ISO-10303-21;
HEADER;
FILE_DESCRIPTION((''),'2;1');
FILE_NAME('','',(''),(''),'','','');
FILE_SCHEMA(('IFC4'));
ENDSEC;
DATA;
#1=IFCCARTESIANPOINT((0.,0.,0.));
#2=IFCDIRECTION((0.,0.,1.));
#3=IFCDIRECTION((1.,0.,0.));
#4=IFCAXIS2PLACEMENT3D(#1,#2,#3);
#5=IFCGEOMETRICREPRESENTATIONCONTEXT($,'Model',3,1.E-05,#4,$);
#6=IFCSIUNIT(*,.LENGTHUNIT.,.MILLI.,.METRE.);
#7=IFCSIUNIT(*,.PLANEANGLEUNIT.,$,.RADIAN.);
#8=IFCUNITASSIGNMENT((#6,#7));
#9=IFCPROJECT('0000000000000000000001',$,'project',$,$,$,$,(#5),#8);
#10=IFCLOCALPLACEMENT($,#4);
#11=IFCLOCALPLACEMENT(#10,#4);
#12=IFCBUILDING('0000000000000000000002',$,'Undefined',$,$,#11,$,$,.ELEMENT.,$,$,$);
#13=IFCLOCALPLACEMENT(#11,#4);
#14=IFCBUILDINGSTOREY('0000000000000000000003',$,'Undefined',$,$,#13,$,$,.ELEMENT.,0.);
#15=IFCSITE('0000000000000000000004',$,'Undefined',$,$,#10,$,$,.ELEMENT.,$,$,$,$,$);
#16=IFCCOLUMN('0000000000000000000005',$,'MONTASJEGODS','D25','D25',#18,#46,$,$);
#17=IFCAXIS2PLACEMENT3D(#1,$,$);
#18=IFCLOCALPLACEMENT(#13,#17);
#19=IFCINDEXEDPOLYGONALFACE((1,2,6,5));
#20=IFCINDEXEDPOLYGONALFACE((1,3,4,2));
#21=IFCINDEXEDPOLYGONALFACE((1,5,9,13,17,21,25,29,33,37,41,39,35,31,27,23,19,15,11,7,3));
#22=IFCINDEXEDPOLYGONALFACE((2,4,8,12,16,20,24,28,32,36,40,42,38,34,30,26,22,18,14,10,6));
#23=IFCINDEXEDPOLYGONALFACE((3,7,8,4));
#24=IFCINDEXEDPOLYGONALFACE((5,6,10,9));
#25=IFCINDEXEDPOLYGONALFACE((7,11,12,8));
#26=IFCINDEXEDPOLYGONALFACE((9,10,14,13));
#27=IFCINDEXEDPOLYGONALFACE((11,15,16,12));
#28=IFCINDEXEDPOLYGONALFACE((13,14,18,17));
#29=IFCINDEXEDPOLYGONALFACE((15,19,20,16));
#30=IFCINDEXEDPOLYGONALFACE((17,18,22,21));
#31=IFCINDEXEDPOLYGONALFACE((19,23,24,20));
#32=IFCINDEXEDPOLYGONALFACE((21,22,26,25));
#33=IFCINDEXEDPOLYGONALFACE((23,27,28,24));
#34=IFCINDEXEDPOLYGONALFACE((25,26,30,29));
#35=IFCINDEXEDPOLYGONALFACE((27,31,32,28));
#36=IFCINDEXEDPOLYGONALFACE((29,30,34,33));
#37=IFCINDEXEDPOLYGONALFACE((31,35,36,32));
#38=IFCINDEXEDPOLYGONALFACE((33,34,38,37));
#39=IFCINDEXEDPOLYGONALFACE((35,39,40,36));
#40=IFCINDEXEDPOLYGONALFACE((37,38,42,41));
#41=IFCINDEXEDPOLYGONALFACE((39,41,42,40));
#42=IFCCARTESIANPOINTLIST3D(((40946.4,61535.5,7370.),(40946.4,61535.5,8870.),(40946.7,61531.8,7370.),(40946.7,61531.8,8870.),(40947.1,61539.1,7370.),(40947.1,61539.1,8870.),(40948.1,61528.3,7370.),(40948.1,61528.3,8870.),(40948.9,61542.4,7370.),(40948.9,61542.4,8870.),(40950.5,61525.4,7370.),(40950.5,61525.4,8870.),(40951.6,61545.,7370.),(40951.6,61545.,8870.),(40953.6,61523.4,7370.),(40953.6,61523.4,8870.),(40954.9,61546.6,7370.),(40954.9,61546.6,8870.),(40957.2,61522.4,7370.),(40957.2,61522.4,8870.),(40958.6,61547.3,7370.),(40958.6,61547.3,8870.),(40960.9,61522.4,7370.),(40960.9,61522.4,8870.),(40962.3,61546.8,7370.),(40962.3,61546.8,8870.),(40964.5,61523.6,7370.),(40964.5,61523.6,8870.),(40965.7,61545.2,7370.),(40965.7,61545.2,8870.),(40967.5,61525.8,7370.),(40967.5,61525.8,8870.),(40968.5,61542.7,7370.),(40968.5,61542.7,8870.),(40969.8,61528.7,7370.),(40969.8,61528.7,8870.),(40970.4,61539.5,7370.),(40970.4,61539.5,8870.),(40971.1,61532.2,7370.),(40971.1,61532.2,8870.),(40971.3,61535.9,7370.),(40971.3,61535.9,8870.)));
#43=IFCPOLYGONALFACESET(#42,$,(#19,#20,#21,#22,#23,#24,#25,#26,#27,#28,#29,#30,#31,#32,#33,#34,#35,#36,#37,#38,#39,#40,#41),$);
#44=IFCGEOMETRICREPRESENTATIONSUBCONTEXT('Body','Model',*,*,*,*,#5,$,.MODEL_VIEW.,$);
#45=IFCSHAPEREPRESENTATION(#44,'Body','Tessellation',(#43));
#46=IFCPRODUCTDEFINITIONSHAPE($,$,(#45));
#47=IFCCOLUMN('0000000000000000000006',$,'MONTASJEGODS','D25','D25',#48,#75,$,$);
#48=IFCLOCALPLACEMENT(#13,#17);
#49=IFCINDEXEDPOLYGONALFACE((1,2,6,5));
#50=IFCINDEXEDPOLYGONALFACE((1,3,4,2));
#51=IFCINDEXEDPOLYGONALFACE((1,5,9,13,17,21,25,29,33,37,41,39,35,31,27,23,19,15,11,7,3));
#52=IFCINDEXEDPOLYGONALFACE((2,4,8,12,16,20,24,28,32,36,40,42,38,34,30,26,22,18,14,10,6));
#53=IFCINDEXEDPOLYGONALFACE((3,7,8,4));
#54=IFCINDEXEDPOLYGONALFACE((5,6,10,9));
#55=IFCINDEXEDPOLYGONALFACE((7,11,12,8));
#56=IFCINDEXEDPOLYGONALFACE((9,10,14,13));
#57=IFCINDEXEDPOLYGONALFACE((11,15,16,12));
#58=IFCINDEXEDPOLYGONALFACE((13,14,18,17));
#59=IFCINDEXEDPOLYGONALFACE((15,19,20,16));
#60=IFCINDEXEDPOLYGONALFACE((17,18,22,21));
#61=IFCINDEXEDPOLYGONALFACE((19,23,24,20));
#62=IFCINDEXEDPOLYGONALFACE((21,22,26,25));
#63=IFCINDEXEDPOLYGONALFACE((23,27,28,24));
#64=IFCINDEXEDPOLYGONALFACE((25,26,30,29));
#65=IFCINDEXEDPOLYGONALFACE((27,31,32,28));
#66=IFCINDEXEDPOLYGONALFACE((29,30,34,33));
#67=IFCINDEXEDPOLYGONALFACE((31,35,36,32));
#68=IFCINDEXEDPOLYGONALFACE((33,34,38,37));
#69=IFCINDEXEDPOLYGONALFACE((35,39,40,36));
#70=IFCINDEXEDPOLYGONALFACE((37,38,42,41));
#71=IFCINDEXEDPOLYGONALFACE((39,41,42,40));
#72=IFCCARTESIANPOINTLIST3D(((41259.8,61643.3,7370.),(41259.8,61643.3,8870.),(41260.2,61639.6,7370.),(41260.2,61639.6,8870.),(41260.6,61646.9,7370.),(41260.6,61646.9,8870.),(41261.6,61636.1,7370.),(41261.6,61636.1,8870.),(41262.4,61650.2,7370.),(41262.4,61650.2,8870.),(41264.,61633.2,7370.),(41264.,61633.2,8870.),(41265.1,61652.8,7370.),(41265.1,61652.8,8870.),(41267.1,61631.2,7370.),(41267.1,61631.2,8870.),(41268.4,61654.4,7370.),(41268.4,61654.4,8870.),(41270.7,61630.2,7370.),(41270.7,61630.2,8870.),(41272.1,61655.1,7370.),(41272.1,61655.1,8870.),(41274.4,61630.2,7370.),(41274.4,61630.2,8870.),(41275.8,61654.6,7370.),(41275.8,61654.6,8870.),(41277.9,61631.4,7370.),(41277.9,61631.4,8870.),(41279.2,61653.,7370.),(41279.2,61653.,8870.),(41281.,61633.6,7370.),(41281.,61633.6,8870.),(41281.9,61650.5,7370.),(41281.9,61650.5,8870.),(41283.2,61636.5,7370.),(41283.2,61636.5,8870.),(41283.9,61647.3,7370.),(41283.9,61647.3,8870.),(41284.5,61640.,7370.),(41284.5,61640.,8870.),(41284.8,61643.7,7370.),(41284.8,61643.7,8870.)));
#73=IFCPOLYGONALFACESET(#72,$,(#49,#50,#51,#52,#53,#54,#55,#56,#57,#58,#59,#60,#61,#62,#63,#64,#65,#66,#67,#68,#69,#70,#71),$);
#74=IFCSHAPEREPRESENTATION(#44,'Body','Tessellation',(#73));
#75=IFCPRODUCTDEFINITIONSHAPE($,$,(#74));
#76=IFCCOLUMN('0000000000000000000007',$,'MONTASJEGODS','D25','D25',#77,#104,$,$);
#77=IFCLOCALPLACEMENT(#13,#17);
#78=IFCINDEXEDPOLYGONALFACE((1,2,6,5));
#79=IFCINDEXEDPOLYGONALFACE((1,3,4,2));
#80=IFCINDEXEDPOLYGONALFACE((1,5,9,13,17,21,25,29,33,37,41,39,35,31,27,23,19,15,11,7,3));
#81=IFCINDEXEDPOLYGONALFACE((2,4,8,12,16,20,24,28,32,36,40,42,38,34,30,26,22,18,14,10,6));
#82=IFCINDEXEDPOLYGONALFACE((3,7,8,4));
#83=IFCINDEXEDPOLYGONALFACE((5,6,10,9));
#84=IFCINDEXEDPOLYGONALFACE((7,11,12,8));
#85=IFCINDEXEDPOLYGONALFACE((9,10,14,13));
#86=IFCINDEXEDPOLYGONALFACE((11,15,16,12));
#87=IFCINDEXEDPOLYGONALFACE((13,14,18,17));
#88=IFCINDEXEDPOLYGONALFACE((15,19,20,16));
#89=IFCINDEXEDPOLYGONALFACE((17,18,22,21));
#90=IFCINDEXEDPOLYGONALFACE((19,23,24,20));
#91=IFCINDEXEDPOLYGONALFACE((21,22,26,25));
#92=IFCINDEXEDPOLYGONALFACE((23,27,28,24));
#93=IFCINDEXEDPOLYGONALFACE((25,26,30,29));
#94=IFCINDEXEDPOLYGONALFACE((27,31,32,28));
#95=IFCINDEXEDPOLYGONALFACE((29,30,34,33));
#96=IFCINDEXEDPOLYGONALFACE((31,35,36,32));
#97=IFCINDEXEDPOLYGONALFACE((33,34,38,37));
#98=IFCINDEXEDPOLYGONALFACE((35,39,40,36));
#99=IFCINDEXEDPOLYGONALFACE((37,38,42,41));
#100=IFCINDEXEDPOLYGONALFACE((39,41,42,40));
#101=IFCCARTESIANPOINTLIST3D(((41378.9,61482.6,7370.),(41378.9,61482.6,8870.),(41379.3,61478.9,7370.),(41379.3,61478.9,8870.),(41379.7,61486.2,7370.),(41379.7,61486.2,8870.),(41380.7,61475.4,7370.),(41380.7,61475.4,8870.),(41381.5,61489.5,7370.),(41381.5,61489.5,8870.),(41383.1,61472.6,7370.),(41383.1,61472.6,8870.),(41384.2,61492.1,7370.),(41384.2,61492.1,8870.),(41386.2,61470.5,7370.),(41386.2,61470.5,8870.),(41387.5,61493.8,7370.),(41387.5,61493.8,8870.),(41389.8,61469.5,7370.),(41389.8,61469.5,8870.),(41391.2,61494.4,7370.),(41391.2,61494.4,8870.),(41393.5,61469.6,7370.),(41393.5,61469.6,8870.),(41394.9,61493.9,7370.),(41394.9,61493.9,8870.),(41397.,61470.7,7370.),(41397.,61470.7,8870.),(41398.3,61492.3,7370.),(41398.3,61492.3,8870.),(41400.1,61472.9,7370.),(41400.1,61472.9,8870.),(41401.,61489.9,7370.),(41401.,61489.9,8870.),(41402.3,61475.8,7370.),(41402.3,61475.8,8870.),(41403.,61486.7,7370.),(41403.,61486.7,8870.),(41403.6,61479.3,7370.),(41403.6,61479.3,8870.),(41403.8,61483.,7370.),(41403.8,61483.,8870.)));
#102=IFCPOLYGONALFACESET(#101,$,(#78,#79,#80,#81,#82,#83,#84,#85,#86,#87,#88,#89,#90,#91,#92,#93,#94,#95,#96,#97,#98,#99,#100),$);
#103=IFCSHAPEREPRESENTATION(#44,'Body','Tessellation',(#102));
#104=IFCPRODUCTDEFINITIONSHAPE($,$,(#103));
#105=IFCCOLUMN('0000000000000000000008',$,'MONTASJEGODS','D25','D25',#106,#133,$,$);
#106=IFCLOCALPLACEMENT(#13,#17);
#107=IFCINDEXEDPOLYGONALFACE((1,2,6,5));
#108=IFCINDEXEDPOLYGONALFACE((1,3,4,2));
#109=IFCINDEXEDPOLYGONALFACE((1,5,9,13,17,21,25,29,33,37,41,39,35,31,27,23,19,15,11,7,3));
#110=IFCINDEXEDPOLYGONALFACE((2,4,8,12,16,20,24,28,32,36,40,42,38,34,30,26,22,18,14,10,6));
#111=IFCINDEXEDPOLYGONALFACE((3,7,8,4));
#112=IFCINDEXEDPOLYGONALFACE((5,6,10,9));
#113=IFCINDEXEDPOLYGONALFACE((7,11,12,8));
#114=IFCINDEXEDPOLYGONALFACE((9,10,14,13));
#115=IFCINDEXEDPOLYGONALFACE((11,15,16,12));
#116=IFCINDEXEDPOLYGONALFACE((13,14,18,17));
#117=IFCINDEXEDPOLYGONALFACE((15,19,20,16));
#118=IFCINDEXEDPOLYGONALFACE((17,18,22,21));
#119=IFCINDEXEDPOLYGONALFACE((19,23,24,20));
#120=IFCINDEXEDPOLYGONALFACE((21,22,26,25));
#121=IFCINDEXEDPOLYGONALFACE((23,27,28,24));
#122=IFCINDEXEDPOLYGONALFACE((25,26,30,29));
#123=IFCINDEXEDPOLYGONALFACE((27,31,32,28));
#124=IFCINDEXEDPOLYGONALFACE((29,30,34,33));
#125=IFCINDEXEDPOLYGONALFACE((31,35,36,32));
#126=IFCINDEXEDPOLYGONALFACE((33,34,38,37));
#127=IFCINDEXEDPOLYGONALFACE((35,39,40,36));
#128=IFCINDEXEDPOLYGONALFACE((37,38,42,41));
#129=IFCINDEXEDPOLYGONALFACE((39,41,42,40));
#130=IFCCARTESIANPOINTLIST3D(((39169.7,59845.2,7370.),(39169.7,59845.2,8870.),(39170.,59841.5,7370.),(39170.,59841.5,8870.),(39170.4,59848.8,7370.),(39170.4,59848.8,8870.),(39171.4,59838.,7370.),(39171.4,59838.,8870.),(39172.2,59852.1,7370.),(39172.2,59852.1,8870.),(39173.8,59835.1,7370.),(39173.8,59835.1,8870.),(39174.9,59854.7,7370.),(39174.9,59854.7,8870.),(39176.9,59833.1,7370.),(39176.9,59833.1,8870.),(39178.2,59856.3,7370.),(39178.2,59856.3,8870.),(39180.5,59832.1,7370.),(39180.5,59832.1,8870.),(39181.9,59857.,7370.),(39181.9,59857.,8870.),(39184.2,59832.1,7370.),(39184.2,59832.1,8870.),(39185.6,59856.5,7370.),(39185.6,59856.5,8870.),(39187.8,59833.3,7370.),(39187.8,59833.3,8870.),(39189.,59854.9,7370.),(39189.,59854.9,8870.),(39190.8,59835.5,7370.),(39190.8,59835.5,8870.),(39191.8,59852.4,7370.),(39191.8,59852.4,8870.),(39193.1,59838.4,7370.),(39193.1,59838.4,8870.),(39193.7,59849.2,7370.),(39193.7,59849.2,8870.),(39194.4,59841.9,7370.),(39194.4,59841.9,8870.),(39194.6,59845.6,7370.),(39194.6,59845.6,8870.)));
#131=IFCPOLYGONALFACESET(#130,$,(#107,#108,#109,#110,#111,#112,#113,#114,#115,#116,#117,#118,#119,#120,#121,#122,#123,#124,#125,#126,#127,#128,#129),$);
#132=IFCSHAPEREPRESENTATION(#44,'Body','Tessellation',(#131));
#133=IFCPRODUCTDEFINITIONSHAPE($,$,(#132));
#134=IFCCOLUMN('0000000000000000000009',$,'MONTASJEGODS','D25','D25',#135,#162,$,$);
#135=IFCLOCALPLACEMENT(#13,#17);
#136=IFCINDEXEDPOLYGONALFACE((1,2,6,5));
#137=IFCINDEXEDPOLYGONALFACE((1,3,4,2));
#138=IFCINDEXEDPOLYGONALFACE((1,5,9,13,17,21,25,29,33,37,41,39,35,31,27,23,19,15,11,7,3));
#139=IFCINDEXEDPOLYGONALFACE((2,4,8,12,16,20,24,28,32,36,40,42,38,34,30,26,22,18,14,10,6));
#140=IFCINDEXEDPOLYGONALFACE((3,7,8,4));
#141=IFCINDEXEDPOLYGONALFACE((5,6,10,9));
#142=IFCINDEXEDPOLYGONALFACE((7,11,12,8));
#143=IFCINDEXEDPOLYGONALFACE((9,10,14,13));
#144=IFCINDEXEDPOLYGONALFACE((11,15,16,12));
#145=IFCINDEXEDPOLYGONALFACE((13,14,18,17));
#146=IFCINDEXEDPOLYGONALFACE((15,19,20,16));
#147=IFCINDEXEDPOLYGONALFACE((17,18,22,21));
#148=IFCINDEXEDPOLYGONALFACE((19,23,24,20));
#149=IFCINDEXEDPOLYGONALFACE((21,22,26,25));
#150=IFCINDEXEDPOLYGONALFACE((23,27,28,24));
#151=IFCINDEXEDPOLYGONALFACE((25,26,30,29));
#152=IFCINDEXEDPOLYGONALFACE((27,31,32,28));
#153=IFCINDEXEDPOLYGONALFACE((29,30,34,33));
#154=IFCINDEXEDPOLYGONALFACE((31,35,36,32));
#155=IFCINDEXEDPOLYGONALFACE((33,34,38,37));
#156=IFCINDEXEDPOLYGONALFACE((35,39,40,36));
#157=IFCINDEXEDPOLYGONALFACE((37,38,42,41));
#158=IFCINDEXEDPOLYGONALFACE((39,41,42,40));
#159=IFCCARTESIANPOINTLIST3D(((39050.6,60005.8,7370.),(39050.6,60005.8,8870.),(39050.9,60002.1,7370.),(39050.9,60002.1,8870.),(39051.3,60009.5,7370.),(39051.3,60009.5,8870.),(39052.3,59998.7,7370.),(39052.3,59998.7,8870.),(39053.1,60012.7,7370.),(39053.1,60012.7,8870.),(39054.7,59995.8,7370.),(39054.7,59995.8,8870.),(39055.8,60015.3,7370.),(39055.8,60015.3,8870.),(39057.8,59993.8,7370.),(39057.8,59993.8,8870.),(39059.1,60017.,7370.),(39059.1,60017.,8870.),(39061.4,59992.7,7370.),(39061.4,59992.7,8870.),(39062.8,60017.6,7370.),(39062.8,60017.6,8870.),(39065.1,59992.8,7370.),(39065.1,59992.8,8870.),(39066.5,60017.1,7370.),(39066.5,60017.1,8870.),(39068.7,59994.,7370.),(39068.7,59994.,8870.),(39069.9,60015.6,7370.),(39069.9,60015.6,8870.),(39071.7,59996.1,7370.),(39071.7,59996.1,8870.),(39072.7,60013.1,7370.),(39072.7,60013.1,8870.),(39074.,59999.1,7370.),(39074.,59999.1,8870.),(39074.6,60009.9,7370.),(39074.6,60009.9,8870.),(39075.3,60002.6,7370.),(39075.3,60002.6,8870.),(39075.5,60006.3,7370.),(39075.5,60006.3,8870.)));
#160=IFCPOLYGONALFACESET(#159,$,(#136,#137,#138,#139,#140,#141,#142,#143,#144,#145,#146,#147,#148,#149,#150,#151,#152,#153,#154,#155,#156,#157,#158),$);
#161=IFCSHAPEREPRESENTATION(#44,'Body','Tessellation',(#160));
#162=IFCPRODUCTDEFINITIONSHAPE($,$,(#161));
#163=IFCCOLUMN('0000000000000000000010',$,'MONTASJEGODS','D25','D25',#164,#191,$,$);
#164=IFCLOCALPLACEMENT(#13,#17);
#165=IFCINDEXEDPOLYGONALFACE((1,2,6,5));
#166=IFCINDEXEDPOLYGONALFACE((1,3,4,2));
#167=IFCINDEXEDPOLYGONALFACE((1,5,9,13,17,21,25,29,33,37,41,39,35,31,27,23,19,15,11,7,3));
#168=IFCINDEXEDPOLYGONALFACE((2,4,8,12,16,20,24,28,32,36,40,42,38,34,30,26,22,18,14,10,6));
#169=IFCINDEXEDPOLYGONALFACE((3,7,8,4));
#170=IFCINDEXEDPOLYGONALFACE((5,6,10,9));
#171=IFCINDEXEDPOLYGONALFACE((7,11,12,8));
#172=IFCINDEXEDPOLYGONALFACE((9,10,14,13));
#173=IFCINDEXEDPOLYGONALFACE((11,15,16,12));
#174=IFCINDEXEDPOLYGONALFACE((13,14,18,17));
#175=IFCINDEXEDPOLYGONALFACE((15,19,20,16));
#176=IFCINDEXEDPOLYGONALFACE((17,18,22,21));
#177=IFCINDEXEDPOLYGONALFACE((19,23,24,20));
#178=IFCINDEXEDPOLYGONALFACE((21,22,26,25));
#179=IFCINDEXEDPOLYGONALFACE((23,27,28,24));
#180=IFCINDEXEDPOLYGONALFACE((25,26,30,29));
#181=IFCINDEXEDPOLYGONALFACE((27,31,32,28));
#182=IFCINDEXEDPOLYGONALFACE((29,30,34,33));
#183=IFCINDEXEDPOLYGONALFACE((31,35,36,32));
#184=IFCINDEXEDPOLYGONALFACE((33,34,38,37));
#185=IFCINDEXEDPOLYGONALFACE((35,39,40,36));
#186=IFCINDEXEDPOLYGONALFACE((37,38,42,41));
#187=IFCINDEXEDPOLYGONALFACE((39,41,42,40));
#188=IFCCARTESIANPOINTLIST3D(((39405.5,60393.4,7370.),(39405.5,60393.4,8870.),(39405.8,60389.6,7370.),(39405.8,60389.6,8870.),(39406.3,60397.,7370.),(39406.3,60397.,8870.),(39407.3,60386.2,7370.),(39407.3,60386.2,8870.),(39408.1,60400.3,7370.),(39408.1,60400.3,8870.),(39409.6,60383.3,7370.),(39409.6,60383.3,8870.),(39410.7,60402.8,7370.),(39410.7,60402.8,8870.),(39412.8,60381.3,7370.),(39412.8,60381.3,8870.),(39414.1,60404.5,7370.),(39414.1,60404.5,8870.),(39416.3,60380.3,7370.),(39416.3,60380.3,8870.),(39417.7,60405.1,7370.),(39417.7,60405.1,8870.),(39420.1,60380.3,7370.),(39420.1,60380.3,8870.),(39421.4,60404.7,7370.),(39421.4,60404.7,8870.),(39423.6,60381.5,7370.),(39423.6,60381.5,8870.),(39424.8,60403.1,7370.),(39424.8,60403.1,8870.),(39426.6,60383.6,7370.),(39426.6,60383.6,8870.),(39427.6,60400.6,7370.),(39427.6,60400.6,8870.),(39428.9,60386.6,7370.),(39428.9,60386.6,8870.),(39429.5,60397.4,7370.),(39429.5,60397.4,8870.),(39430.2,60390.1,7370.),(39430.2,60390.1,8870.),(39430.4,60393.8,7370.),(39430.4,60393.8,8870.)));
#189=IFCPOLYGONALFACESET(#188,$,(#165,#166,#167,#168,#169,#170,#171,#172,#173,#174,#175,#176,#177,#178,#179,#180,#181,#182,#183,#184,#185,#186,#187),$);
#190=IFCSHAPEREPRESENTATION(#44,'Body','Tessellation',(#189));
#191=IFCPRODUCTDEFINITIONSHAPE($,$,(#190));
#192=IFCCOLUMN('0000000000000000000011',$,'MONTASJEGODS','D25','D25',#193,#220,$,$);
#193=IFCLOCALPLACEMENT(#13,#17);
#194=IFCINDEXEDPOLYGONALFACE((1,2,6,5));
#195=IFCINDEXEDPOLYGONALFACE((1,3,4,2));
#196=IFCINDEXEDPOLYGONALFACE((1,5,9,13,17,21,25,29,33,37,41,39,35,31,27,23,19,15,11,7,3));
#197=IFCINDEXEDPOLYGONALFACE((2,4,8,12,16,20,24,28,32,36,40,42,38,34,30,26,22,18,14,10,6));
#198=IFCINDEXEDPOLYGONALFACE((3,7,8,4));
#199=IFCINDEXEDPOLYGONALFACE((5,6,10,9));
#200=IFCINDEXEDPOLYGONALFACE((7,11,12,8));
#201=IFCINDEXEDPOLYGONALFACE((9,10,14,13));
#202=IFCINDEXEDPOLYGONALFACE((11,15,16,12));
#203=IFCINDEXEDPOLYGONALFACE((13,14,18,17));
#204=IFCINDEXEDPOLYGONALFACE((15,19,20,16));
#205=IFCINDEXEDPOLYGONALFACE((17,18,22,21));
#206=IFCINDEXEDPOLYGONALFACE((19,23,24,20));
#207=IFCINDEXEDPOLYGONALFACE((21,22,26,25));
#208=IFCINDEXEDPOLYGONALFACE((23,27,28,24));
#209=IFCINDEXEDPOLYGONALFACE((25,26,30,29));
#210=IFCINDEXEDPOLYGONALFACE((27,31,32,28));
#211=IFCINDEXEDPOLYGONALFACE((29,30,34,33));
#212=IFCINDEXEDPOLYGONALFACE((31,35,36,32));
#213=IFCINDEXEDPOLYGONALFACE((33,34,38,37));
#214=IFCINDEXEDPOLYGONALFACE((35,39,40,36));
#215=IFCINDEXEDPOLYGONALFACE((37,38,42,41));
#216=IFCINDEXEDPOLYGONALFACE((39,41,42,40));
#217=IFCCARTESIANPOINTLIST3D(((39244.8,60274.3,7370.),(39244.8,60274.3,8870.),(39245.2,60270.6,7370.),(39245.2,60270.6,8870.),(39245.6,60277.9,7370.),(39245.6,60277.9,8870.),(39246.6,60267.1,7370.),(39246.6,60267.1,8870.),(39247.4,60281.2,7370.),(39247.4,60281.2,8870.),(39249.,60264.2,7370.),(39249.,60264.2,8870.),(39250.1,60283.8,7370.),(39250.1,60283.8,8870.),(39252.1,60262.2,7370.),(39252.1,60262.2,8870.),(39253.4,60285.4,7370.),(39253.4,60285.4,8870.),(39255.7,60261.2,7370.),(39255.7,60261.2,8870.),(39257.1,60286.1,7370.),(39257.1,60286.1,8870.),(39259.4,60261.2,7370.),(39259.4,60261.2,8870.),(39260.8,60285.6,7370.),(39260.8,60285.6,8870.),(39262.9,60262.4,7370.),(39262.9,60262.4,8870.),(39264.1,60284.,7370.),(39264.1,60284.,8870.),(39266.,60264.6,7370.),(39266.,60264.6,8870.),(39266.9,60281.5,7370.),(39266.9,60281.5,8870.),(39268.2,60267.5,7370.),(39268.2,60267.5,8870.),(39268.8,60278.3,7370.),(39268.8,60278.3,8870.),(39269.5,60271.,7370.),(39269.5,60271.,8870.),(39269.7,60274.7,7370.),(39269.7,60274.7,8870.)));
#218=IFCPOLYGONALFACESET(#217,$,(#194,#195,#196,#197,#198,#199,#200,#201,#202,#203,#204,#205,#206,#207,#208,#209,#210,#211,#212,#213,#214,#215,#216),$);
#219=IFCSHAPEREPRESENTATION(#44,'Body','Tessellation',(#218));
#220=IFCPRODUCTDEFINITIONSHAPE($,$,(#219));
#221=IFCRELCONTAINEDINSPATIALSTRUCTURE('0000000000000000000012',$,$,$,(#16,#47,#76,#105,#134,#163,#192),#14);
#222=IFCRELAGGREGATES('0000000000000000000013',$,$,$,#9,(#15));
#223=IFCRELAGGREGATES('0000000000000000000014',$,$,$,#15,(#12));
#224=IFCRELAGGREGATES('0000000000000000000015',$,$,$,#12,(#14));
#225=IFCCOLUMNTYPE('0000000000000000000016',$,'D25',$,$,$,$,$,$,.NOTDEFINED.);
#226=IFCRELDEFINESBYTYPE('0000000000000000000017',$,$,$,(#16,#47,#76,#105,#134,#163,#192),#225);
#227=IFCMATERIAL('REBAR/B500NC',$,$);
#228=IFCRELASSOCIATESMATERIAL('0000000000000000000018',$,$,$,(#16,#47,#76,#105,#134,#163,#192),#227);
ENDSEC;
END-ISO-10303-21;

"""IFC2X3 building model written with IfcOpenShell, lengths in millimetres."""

from ifc_helpers import new_model, si_unit, frame, origin_with_axes, origin_2d_with_axis, place, context, subcontext, project, spatial, circle, extrude, material, type_object, element, save


model = new_model("IFC2X3")

# Units and contexts
model_context = context("Model", 3, precision=1e-05, world=origin_with_axes())
body_context = subcontext(model_context, "Body", "Model", "MODEL_VIEW")
ifc_project = project(units=[si_unit("LENGTHUNIT", "METRE", prefix="MILLI"), si_unit("PLANEANGLEUNIT", "RADIAN")], contexts=[model_context])

# Site, building, storey
site_placement = place(None, origin_with_axes())
site = spatial("IfcSite", under=ifc_project, at=site_placement, Name="Undefined", CompositionType="ELEMENT")
building_placement = place(site_placement, origin_with_axes())
building = spatial("IfcBuilding", under=site, at=building_placement, Name="Undefined", CompositionType="ELEMENT")
storey_placement = place(building_placement, origin_with_axes())
storey = spatial("IfcBuildingStorey", under=building, at=storey_placement, Name="Undefined", CompositionType="ELEMENT", Elevation=0.0)

# Columns
ifc_material_1 = material(Name="REBAR/B500NC")
column_type_1 = type_object("IfcColumnType", Name="D25", PredefinedType="NOTDEFINED")
for number, where, z_axis, x_axis, name in (
    (1, (40958.8, 61534.8, 7370.0), (0.0, 0.0, 1.0), (-0.892819, -0.450415, 0.0), "MONTASJEGODS"),
    (2, (41272.3, 61642.6, 7370.0), (0.0, 0.0, 1.0), (-0.892819, -0.450415, 0.0), "MONTASJEGODS"),
    (3, (41391.4, 61481.9, 7370.0), (0.0, 0.0, 1.0), (-0.892819, -0.450415, 0.0), "MONTASJEGODS"),
    (4, (39182.1, 59844.5, 7370.0), (0.0, 0.0, 1.0), (-0.892819, -0.450415, 0.0), "MONTASJEGODS"),
    (5, (39063.0, 60005.1, 7370.0), (0.0, 0.0, 1.0), (-0.892819, -0.450415, 0.0), "MONTASJEGODS"),
    (6, (39418.0, 60392.6, 7370.0), (0.0, 0.0, 1.0), (-0.892819, -0.450415, 0.0), "MONTASJEGODS"),
    (7, (39257.3, 60273.6, 7370.0), (0.0, 0.0, 1.0), (-0.892819, -0.450415, 0.0), "MONTASJEGODS"),
):
    element("IfcColumn", number, at=place(storey_placement, frame(where, z_axis=z_axis, x_axis=x_axis)), inside=storey, type_object=column_type_1, material=ifc_material_1, Name=name, Description="D25", ObjectType="D25", context=body_context, shape_type="SweptSolid", body=[
        extrude(circle(Radius=12.5, at=origin_2d_with_axis()), frame((0.0, 0.0, 1500.0), z_axis=(0.0, 0.0, -1.0), x_axis=(0.0, 1.0, 0.0)), (0.0, 0.0, 1.0), 1500.0),
    ])

save(model, "model.ifc")
